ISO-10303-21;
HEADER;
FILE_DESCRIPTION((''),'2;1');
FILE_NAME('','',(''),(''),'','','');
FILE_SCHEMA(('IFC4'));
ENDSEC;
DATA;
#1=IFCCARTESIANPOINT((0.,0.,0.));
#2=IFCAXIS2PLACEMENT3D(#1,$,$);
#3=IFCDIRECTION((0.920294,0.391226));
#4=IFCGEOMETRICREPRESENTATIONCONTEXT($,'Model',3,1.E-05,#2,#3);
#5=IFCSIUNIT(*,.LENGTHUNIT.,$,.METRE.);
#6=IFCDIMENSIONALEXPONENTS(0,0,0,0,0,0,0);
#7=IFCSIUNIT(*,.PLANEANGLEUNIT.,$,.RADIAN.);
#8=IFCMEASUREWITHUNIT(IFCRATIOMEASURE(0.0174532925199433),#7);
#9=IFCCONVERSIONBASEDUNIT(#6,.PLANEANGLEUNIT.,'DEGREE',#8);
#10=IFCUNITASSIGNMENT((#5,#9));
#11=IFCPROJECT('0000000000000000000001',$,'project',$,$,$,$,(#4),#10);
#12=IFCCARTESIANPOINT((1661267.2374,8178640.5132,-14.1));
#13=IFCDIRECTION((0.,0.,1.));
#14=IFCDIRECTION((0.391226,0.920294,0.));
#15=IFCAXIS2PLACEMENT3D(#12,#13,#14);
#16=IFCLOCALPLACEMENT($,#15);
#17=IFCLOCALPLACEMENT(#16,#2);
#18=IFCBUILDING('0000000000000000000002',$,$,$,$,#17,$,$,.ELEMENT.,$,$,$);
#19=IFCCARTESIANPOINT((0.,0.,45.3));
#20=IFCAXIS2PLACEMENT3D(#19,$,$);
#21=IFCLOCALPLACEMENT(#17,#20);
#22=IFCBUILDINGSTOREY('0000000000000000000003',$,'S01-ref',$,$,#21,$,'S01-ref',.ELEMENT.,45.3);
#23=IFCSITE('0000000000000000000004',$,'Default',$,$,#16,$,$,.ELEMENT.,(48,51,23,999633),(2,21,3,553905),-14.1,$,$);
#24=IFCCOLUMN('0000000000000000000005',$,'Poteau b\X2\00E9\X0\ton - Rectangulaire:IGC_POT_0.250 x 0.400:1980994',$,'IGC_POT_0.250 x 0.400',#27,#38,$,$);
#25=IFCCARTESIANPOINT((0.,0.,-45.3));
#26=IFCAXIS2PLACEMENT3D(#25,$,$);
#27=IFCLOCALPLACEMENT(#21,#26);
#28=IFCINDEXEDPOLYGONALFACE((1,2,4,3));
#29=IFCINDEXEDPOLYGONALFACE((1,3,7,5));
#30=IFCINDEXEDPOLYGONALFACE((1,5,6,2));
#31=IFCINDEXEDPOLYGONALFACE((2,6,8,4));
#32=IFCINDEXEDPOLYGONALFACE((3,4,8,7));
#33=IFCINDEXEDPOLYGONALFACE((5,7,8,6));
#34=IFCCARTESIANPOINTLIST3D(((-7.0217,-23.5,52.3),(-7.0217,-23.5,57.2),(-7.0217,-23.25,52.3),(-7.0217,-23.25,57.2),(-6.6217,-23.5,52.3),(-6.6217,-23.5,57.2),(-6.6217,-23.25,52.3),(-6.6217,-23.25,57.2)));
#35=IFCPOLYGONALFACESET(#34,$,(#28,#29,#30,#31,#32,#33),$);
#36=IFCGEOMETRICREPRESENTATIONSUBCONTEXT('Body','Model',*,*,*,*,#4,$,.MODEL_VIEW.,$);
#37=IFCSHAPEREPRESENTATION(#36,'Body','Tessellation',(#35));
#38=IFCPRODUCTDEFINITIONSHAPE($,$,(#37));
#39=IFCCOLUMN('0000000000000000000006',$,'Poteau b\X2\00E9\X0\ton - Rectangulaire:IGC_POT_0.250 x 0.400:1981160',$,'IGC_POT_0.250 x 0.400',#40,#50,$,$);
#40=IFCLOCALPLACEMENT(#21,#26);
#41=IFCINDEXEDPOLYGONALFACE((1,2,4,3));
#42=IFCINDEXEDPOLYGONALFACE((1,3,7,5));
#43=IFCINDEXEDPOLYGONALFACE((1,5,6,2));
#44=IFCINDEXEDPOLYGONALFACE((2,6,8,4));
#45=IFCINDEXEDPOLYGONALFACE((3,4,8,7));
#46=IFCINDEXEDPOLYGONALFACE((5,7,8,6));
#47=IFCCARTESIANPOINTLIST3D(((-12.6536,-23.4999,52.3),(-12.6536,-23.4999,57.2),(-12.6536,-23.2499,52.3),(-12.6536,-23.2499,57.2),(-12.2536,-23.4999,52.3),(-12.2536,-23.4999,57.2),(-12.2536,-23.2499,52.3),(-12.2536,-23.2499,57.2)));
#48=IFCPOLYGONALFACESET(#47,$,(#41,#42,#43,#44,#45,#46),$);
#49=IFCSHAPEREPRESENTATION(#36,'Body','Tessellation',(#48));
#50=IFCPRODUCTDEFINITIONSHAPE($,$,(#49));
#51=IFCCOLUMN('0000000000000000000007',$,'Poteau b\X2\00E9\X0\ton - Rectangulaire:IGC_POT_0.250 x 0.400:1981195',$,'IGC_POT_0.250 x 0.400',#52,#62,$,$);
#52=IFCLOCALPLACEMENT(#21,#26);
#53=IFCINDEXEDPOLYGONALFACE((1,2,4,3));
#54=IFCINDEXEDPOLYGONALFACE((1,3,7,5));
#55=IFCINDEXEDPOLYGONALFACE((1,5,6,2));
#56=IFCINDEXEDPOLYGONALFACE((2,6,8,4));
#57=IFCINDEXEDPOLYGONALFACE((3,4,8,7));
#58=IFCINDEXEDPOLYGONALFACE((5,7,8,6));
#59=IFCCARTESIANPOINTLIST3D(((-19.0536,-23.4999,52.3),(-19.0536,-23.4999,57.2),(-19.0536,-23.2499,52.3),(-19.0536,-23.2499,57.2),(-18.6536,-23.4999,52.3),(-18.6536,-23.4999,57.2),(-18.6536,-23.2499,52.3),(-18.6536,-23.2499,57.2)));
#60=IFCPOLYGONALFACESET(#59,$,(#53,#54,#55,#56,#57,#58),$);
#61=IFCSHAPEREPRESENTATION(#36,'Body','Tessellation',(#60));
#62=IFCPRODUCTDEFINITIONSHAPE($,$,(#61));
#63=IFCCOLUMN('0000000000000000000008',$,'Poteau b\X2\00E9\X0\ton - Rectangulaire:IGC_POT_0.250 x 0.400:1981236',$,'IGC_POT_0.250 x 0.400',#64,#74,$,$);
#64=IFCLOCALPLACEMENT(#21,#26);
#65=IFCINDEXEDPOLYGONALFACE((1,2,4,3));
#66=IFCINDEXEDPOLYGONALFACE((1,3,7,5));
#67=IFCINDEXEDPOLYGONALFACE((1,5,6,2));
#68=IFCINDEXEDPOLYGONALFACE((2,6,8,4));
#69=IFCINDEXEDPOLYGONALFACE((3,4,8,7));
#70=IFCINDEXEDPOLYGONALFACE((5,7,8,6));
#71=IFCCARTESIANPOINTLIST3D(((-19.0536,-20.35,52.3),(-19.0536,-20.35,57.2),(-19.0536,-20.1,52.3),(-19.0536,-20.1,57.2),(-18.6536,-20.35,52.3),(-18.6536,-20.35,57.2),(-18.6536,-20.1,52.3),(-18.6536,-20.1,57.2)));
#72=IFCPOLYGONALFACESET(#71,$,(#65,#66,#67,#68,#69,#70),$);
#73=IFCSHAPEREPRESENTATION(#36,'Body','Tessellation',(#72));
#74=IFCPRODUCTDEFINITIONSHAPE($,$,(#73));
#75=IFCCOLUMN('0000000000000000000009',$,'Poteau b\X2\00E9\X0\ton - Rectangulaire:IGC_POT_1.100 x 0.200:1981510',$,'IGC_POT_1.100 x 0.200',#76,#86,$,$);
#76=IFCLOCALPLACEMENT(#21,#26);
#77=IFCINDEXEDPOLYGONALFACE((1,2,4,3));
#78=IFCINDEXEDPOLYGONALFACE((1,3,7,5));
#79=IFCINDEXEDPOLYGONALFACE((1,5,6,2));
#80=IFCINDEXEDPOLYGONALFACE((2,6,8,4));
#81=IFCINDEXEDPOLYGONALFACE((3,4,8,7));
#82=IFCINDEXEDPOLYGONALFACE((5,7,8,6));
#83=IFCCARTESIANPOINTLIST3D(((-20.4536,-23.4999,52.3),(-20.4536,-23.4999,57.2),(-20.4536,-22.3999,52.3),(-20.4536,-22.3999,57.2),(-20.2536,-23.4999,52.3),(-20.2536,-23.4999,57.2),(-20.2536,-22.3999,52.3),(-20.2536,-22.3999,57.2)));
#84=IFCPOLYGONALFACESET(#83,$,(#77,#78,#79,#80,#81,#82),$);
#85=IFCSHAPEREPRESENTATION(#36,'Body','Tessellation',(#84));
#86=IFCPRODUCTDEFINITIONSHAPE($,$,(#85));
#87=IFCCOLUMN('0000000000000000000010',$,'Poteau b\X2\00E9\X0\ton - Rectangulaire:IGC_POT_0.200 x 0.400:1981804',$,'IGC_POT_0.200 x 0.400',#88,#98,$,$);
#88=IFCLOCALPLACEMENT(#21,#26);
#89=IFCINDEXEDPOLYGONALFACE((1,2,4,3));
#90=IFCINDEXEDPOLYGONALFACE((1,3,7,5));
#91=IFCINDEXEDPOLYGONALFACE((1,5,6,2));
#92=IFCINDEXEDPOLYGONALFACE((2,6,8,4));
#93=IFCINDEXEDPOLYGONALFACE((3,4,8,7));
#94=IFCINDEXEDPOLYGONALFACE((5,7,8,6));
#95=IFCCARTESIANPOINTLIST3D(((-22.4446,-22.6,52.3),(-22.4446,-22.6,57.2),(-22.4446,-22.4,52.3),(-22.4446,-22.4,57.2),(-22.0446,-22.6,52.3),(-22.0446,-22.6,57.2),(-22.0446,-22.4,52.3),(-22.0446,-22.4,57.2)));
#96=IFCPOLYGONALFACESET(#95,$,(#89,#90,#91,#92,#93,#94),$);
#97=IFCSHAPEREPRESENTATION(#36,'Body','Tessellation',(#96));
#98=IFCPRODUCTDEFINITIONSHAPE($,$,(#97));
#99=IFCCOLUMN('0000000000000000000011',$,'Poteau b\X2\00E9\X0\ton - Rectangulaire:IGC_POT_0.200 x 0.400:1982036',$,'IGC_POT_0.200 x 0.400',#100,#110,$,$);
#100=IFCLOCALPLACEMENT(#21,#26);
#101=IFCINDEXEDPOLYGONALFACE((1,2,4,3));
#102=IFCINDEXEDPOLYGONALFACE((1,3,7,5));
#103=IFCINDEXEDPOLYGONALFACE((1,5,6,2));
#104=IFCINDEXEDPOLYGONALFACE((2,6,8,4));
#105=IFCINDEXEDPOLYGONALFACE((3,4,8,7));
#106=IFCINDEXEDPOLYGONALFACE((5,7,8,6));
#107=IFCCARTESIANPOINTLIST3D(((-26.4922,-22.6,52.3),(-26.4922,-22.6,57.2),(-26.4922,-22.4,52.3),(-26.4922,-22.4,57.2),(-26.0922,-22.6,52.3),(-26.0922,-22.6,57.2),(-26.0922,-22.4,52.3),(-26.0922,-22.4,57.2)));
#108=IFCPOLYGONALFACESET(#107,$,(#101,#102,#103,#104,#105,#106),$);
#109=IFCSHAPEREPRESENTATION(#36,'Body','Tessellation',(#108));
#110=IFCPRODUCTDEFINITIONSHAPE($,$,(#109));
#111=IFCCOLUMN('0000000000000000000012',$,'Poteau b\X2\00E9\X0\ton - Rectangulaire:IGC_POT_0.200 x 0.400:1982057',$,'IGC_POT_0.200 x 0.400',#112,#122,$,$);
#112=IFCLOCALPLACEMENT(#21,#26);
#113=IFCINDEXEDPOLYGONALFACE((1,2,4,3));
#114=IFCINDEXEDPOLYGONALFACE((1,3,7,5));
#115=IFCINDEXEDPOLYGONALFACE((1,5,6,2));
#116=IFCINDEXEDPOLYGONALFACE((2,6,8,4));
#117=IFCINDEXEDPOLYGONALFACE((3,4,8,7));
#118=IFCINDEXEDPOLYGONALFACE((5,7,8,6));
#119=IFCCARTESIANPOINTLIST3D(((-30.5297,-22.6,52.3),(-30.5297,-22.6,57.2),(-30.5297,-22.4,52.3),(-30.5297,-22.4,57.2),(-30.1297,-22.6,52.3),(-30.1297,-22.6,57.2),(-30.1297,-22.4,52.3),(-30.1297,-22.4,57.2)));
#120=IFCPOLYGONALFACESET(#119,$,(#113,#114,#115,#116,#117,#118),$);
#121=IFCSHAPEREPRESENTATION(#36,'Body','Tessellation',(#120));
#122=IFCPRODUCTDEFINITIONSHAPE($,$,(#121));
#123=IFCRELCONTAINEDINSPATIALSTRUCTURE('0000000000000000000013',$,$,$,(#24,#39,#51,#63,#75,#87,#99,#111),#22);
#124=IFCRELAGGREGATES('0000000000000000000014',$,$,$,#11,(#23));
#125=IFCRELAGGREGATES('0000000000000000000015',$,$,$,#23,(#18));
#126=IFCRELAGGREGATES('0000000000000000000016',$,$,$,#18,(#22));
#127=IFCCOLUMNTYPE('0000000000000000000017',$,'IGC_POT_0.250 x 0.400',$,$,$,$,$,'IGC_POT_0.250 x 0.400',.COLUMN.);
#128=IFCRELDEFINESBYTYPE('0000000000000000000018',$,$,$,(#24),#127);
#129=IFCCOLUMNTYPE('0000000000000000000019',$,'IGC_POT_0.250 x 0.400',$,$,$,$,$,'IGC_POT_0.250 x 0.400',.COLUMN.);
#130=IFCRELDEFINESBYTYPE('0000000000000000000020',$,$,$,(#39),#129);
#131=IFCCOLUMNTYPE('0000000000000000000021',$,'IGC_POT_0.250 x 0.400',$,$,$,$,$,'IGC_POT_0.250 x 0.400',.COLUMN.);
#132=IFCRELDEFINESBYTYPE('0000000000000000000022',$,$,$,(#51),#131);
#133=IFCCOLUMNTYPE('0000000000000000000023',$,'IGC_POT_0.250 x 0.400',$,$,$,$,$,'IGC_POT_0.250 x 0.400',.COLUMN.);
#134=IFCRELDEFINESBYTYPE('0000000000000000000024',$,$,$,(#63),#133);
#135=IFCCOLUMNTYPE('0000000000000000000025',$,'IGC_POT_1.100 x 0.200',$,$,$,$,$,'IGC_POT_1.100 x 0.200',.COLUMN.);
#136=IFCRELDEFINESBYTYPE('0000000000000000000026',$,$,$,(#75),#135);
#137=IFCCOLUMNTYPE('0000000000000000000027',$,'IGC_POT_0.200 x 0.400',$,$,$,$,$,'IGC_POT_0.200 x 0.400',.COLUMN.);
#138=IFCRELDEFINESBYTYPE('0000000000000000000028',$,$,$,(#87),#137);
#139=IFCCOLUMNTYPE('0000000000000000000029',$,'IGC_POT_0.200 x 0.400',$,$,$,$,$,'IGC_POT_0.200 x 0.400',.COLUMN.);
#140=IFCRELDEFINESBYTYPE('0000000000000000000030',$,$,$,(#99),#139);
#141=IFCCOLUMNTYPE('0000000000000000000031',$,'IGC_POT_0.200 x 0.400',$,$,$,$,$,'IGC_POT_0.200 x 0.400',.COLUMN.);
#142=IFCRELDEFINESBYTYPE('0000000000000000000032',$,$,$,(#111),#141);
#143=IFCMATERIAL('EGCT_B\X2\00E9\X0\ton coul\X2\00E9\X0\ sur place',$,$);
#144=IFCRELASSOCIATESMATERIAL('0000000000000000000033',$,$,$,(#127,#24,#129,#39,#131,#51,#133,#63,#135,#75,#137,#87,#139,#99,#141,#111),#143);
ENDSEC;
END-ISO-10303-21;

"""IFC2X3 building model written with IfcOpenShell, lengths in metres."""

from ifc_helpers import new_model, entity, si_unit, converted_unit, direction, frame, frame_2d, origin, origin_2d_with_axis, place, context, subcontext, project, spatial, rectangle, extrude, source, transform, mapped, material, type_object, type_shapes, element, save


model = new_model("IFC2X3")

# Units and contexts
model_context = context("Model", 3, precision=1e-05, world=origin(), true_north=direction((0.920294, 0.391226)))
body_context = subcontext(model_context, "Body", "Model", "MODEL_VIEW")
ifc_project = project(units=[si_unit("LENGTHUNIT", "METRE"), converted_unit("PLANEANGLEUNIT", "DEGREE", entity("IfcRatioMeasure", 0.0174532925199433), si_unit("PLANEANGLEUNIT", "RADIAN"), dimensions=[0, 0, 0, 0, 0, 0, 0])], contexts=[model_context])

# Site, building, storey
site_placement = place(None, frame((1661267.2374, 8178640.5132, -14.1), z_axis=(0.0, 0.0, 1.0), x_axis=(0.391226, 0.920294, 0.0)))
site = spatial("IfcSite", under=ifc_project, at=site_placement, Name="Default", CompositionType="ELEMENT", RefLatitude=(48, 51, 23, 999633), RefLongitude=(2, 21, 3, 553905), RefElevation=-14.1)
building_placement = place(site_placement, origin())
building = spatial("IfcBuilding", under=site, at=building_placement, CompositionType="ELEMENT")
storey_placement = place(building_placement, frame((0.0, 0.0, 45.3)))
storey = spatial("IfcBuildingStorey", under=building, at=storey_placement, Name="S01-ref", LongName="S01-ref", CompositionType="ELEMENT", Elevation=45.3)

# Columns
ifc_material_1 = material(Name="EGCT_Béton coulé sur place")
column_type_1 = type_object("IfcColumnType", Name="IGC_POT_0.250 x 0.400", ElementType="IGC_POT_0.250 x 0.400", PredefinedType="COLUMN", material=ifc_material_1)
shared_shape_1 = source(origin(), body_context, "Body", "SweptSolid", [
    extrude(rectangle(XDim=0.25, YDim=0.4, at=origin_2d_with_axis()), frame((-6.8217, -23.375, 52.3), z_axis=(0.0, 0.0, 1.0), x_axis=(0.0, -1.0, 0.0)), (0.0, 0.0, 1.0), 4.9),
])
type_shapes(column_type_1, [shared_shape_1])
column_1_placement = place(storey_placement, frame((0.0, 0.0, -45.3)))
element("IfcColumn", 1, at=column_1_placement, inside=storey, type_object=column_type_1, material=ifc_material_1, Name="Poteau béton - Rectangulaire:IGC_POT_0.250 x 0.400:1980994", ObjectType="IGC_POT_0.250 x 0.400", context=body_context, shape_type="MappedRepresentation", body=[
    mapped(shared_shape_1, transform((0.0, 0.0, 0.0), scale=1.0)),
])
column_type_2 = type_object("IfcColumnType", Name="IGC_POT_0.250 x 0.400", ElementType="IGC_POT_0.250 x 0.400", PredefinedType="COLUMN", material=ifc_material_1)
shared_shape_2 = source(origin(), body_context, "Body", "SweptSolid", [
    extrude(rectangle(XDim=0.25, YDim=0.4, at=origin_2d_with_axis()), frame((-12.4536, -23.3749, 52.3), z_axis=(0.0, 0.0, 1.0), x_axis=(0.0, -1.0, 0.0)), (0.0, 0.0, 1.0), 4.9),
])
type_shapes(column_type_2, [shared_shape_2])
column_2_placement = place(storey_placement, frame((0.0, 0.0, -45.3)))
element("IfcColumn", 2, at=column_2_placement, inside=storey, type_object=column_type_2, material=ifc_material_1, Name="Poteau béton - Rectangulaire:IGC_POT_0.250 x 0.400:1981160", ObjectType="IGC_POT_0.250 x 0.400", context=body_context, shape_type="MappedRepresentation", body=[
    mapped(shared_shape_2, transform((0.0, 0.0, 0.0), scale=1.0)),
])
column_type_3 = type_object("IfcColumnType", Name="IGC_POT_0.250 x 0.400", ElementType="IGC_POT_0.250 x 0.400", PredefinedType="COLUMN", material=ifc_material_1)
shared_shape_3 = source(origin(), body_context, "Body", "SweptSolid", [
    extrude(rectangle(XDim=0.25, YDim=0.4, at=origin_2d_with_axis()), frame((-18.8536, -23.3749, 52.3), z_axis=(0.0, 0.0, 1.0), x_axis=(0.0, -1.0, 0.0)), (0.0, 0.0, 1.0), 4.9),
])
type_shapes(column_type_3, [shared_shape_3])
column_3_placement = place(storey_placement, frame((0.0, 0.0, -45.3)))
element("IfcColumn", 3, at=column_3_placement, inside=storey, type_object=column_type_3, material=ifc_material_1, Name="Poteau béton - Rectangulaire:IGC_POT_0.250 x 0.400:1981195", ObjectType="IGC_POT_0.250 x 0.400", context=body_context, shape_type="MappedRepresentation", body=[
    mapped(shared_shape_3, transform((0.0, 0.0, 0.0), scale=1.0)),
])
column_type_4 = type_object("IfcColumnType", Name="IGC_POT_0.250 x 0.400", ElementType="IGC_POT_0.250 x 0.400", PredefinedType="COLUMN", material=ifc_material_1)
shared_shape_4 = source(origin(), body_context, "Body", "SweptSolid", [
    extrude(rectangle(XDim=0.25, YDim=0.4, at=origin_2d_with_axis()), frame((-18.8536, -20.225, 52.3), z_axis=(0.0, 0.0, 1.0), x_axis=(0.0, -1.0, 0.0)), (0.0, 0.0, 1.0), 4.9),
])
type_shapes(column_type_4, [shared_shape_4])
column_4_placement = place(storey_placement, frame((0.0, 0.0, -45.3)))
element("IfcColumn", 4, at=column_4_placement, inside=storey, type_object=column_type_4, material=ifc_material_1, Name="Poteau béton - Rectangulaire:IGC_POT_0.250 x 0.400:1981236", ObjectType="IGC_POT_0.250 x 0.400", context=body_context, shape_type="MappedRepresentation", body=[
    mapped(shared_shape_4, transform((0.0, 0.0, 0.0), scale=1.0)),
])
column_type_5 = type_object("IfcColumnType", Name="IGC_POT_1.100 x 0.200", ElementType="IGC_POT_1.100 x 0.200", PredefinedType="COLUMN", material=ifc_material_1)
shared_shape_5 = source(origin(), body_context, "Body", "SweptSolid", [
    extrude(rectangle(XDim=1.1, YDim=0.2, at=origin_2d_with_axis()), frame((-20.3536, -22.9499, 52.3), z_axis=(0.0, 0.0, 1.0), x_axis=(0.0, -1.0, 0.0)), (0.0, 0.0, 1.0), 4.9),
])
type_shapes(column_type_5, [shared_shape_5])
column_5_placement = place(storey_placement, frame((0.0, 0.0, -45.3)))
element("IfcColumn", 5, at=column_5_placement, inside=storey, type_object=column_type_5, material=ifc_material_1, Name="Poteau béton - Rectangulaire:IGC_POT_1.100 x 0.200:1981510", ObjectType="IGC_POT_1.100 x 0.200", context=body_context, shape_type="MappedRepresentation", body=[
    mapped(shared_shape_5, transform((0.0, 0.0, 0.0), scale=1.0)),
])
column_type_6 = type_object("IfcColumnType", Name="IGC_POT_0.200 x 0.400", ElementType="IGC_POT_0.200 x 0.400", PredefinedType="COLUMN", material=ifc_material_1)
shared_shape_6 = source(origin(), body_context, "Body", "SweptSolid", [
    extrude(rectangle(XDim=0.2, YDim=0.4, at=frame_2d((0.0, 0.0), x_axis=(1.0, 0.0))), frame((-22.2446, -22.5, 52.3), z_axis=(0.0, 0.0, 1.0), x_axis=(0.0, -1.0, 0.0)), (0.0, 0.0, 1.0), 4.9),
])
type_shapes(column_type_6, [shared_shape_6])
column_6_placement = place(storey_placement, frame((0.0, 0.0, -45.3)))
element("IfcColumn", 6, at=column_6_placement, inside=storey, type_object=column_type_6, material=ifc_material_1, Name="Poteau béton - Rectangulaire:IGC_POT_0.200 x 0.400:1981804", ObjectType="IGC_POT_0.200 x 0.400", context=body_context, shape_type="MappedRepresentation", body=[
    mapped(shared_shape_6, transform((0.0, 0.0, 0.0), scale=1.0)),
])
column_type_7 = type_object("IfcColumnType", Name="IGC_POT_0.200 x 0.400", ElementType="IGC_POT_0.200 x 0.400", PredefinedType="COLUMN", material=ifc_material_1)
shared_shape_7 = source(origin(), body_context, "Body", "SweptSolid", [
    extrude(rectangle(XDim=0.2, YDim=0.4, at=frame_2d((0.0, 0.0), x_axis=(1.0, 0.0))), frame((-26.2922, -22.5, 52.3), z_axis=(0.0, 0.0, 1.0), x_axis=(0.0, -1.0, 0.0)), (0.0, 0.0, 1.0), 4.9),
])
type_shapes(column_type_7, [shared_shape_7])
column_7_placement = place(storey_placement, frame((0.0, 0.0, -45.3)))
element("IfcColumn", 7, at=column_7_placement, inside=storey, type_object=column_type_7, material=ifc_material_1, Name="Poteau béton - Rectangulaire:IGC_POT_0.200 x 0.400:1982036", ObjectType="IGC_POT_0.200 x 0.400", context=body_context, shape_type="MappedRepresentation", body=[
    mapped(shared_shape_7, transform((0.0, 0.0, 0.0), scale=1.0)),
])
column_type_8 = type_object("IfcColumnType", Name="IGC_POT_0.200 x 0.400", ElementType="IGC_POT_0.200 x 0.400", PredefinedType="COLUMN", material=ifc_material_1)
shared_shape_8 = source(origin(), body_context, "Body", "SweptSolid", [
    extrude(rectangle(XDim=0.2, YDim=0.4, at=frame_2d((0.0, 0.0), x_axis=(1.0, 0.0))), frame((-30.3297, -22.5, 52.3), z_axis=(0.0, 0.0, 1.0), x_axis=(0.0, -1.0, 0.0)), (0.0, 0.0, 1.0), 4.9),
])
type_shapes(column_type_8, [shared_shape_8])
column_8_placement = place(storey_placement, frame((0.0, 0.0, -45.3)))
element("IfcColumn", 8, at=column_8_placement, inside=storey, type_object=column_type_8, material=ifc_material_1, Name="Poteau béton - Rectangulaire:IGC_POT_0.200 x 0.400:1982057", ObjectType="IGC_POT_0.200 x 0.400", context=body_context, shape_type="MappedRepresentation", body=[
    mapped(shared_shape_8, transform((0.0, 0.0, 0.0), scale=1.0)),
])

save(model, "model.ifc")
